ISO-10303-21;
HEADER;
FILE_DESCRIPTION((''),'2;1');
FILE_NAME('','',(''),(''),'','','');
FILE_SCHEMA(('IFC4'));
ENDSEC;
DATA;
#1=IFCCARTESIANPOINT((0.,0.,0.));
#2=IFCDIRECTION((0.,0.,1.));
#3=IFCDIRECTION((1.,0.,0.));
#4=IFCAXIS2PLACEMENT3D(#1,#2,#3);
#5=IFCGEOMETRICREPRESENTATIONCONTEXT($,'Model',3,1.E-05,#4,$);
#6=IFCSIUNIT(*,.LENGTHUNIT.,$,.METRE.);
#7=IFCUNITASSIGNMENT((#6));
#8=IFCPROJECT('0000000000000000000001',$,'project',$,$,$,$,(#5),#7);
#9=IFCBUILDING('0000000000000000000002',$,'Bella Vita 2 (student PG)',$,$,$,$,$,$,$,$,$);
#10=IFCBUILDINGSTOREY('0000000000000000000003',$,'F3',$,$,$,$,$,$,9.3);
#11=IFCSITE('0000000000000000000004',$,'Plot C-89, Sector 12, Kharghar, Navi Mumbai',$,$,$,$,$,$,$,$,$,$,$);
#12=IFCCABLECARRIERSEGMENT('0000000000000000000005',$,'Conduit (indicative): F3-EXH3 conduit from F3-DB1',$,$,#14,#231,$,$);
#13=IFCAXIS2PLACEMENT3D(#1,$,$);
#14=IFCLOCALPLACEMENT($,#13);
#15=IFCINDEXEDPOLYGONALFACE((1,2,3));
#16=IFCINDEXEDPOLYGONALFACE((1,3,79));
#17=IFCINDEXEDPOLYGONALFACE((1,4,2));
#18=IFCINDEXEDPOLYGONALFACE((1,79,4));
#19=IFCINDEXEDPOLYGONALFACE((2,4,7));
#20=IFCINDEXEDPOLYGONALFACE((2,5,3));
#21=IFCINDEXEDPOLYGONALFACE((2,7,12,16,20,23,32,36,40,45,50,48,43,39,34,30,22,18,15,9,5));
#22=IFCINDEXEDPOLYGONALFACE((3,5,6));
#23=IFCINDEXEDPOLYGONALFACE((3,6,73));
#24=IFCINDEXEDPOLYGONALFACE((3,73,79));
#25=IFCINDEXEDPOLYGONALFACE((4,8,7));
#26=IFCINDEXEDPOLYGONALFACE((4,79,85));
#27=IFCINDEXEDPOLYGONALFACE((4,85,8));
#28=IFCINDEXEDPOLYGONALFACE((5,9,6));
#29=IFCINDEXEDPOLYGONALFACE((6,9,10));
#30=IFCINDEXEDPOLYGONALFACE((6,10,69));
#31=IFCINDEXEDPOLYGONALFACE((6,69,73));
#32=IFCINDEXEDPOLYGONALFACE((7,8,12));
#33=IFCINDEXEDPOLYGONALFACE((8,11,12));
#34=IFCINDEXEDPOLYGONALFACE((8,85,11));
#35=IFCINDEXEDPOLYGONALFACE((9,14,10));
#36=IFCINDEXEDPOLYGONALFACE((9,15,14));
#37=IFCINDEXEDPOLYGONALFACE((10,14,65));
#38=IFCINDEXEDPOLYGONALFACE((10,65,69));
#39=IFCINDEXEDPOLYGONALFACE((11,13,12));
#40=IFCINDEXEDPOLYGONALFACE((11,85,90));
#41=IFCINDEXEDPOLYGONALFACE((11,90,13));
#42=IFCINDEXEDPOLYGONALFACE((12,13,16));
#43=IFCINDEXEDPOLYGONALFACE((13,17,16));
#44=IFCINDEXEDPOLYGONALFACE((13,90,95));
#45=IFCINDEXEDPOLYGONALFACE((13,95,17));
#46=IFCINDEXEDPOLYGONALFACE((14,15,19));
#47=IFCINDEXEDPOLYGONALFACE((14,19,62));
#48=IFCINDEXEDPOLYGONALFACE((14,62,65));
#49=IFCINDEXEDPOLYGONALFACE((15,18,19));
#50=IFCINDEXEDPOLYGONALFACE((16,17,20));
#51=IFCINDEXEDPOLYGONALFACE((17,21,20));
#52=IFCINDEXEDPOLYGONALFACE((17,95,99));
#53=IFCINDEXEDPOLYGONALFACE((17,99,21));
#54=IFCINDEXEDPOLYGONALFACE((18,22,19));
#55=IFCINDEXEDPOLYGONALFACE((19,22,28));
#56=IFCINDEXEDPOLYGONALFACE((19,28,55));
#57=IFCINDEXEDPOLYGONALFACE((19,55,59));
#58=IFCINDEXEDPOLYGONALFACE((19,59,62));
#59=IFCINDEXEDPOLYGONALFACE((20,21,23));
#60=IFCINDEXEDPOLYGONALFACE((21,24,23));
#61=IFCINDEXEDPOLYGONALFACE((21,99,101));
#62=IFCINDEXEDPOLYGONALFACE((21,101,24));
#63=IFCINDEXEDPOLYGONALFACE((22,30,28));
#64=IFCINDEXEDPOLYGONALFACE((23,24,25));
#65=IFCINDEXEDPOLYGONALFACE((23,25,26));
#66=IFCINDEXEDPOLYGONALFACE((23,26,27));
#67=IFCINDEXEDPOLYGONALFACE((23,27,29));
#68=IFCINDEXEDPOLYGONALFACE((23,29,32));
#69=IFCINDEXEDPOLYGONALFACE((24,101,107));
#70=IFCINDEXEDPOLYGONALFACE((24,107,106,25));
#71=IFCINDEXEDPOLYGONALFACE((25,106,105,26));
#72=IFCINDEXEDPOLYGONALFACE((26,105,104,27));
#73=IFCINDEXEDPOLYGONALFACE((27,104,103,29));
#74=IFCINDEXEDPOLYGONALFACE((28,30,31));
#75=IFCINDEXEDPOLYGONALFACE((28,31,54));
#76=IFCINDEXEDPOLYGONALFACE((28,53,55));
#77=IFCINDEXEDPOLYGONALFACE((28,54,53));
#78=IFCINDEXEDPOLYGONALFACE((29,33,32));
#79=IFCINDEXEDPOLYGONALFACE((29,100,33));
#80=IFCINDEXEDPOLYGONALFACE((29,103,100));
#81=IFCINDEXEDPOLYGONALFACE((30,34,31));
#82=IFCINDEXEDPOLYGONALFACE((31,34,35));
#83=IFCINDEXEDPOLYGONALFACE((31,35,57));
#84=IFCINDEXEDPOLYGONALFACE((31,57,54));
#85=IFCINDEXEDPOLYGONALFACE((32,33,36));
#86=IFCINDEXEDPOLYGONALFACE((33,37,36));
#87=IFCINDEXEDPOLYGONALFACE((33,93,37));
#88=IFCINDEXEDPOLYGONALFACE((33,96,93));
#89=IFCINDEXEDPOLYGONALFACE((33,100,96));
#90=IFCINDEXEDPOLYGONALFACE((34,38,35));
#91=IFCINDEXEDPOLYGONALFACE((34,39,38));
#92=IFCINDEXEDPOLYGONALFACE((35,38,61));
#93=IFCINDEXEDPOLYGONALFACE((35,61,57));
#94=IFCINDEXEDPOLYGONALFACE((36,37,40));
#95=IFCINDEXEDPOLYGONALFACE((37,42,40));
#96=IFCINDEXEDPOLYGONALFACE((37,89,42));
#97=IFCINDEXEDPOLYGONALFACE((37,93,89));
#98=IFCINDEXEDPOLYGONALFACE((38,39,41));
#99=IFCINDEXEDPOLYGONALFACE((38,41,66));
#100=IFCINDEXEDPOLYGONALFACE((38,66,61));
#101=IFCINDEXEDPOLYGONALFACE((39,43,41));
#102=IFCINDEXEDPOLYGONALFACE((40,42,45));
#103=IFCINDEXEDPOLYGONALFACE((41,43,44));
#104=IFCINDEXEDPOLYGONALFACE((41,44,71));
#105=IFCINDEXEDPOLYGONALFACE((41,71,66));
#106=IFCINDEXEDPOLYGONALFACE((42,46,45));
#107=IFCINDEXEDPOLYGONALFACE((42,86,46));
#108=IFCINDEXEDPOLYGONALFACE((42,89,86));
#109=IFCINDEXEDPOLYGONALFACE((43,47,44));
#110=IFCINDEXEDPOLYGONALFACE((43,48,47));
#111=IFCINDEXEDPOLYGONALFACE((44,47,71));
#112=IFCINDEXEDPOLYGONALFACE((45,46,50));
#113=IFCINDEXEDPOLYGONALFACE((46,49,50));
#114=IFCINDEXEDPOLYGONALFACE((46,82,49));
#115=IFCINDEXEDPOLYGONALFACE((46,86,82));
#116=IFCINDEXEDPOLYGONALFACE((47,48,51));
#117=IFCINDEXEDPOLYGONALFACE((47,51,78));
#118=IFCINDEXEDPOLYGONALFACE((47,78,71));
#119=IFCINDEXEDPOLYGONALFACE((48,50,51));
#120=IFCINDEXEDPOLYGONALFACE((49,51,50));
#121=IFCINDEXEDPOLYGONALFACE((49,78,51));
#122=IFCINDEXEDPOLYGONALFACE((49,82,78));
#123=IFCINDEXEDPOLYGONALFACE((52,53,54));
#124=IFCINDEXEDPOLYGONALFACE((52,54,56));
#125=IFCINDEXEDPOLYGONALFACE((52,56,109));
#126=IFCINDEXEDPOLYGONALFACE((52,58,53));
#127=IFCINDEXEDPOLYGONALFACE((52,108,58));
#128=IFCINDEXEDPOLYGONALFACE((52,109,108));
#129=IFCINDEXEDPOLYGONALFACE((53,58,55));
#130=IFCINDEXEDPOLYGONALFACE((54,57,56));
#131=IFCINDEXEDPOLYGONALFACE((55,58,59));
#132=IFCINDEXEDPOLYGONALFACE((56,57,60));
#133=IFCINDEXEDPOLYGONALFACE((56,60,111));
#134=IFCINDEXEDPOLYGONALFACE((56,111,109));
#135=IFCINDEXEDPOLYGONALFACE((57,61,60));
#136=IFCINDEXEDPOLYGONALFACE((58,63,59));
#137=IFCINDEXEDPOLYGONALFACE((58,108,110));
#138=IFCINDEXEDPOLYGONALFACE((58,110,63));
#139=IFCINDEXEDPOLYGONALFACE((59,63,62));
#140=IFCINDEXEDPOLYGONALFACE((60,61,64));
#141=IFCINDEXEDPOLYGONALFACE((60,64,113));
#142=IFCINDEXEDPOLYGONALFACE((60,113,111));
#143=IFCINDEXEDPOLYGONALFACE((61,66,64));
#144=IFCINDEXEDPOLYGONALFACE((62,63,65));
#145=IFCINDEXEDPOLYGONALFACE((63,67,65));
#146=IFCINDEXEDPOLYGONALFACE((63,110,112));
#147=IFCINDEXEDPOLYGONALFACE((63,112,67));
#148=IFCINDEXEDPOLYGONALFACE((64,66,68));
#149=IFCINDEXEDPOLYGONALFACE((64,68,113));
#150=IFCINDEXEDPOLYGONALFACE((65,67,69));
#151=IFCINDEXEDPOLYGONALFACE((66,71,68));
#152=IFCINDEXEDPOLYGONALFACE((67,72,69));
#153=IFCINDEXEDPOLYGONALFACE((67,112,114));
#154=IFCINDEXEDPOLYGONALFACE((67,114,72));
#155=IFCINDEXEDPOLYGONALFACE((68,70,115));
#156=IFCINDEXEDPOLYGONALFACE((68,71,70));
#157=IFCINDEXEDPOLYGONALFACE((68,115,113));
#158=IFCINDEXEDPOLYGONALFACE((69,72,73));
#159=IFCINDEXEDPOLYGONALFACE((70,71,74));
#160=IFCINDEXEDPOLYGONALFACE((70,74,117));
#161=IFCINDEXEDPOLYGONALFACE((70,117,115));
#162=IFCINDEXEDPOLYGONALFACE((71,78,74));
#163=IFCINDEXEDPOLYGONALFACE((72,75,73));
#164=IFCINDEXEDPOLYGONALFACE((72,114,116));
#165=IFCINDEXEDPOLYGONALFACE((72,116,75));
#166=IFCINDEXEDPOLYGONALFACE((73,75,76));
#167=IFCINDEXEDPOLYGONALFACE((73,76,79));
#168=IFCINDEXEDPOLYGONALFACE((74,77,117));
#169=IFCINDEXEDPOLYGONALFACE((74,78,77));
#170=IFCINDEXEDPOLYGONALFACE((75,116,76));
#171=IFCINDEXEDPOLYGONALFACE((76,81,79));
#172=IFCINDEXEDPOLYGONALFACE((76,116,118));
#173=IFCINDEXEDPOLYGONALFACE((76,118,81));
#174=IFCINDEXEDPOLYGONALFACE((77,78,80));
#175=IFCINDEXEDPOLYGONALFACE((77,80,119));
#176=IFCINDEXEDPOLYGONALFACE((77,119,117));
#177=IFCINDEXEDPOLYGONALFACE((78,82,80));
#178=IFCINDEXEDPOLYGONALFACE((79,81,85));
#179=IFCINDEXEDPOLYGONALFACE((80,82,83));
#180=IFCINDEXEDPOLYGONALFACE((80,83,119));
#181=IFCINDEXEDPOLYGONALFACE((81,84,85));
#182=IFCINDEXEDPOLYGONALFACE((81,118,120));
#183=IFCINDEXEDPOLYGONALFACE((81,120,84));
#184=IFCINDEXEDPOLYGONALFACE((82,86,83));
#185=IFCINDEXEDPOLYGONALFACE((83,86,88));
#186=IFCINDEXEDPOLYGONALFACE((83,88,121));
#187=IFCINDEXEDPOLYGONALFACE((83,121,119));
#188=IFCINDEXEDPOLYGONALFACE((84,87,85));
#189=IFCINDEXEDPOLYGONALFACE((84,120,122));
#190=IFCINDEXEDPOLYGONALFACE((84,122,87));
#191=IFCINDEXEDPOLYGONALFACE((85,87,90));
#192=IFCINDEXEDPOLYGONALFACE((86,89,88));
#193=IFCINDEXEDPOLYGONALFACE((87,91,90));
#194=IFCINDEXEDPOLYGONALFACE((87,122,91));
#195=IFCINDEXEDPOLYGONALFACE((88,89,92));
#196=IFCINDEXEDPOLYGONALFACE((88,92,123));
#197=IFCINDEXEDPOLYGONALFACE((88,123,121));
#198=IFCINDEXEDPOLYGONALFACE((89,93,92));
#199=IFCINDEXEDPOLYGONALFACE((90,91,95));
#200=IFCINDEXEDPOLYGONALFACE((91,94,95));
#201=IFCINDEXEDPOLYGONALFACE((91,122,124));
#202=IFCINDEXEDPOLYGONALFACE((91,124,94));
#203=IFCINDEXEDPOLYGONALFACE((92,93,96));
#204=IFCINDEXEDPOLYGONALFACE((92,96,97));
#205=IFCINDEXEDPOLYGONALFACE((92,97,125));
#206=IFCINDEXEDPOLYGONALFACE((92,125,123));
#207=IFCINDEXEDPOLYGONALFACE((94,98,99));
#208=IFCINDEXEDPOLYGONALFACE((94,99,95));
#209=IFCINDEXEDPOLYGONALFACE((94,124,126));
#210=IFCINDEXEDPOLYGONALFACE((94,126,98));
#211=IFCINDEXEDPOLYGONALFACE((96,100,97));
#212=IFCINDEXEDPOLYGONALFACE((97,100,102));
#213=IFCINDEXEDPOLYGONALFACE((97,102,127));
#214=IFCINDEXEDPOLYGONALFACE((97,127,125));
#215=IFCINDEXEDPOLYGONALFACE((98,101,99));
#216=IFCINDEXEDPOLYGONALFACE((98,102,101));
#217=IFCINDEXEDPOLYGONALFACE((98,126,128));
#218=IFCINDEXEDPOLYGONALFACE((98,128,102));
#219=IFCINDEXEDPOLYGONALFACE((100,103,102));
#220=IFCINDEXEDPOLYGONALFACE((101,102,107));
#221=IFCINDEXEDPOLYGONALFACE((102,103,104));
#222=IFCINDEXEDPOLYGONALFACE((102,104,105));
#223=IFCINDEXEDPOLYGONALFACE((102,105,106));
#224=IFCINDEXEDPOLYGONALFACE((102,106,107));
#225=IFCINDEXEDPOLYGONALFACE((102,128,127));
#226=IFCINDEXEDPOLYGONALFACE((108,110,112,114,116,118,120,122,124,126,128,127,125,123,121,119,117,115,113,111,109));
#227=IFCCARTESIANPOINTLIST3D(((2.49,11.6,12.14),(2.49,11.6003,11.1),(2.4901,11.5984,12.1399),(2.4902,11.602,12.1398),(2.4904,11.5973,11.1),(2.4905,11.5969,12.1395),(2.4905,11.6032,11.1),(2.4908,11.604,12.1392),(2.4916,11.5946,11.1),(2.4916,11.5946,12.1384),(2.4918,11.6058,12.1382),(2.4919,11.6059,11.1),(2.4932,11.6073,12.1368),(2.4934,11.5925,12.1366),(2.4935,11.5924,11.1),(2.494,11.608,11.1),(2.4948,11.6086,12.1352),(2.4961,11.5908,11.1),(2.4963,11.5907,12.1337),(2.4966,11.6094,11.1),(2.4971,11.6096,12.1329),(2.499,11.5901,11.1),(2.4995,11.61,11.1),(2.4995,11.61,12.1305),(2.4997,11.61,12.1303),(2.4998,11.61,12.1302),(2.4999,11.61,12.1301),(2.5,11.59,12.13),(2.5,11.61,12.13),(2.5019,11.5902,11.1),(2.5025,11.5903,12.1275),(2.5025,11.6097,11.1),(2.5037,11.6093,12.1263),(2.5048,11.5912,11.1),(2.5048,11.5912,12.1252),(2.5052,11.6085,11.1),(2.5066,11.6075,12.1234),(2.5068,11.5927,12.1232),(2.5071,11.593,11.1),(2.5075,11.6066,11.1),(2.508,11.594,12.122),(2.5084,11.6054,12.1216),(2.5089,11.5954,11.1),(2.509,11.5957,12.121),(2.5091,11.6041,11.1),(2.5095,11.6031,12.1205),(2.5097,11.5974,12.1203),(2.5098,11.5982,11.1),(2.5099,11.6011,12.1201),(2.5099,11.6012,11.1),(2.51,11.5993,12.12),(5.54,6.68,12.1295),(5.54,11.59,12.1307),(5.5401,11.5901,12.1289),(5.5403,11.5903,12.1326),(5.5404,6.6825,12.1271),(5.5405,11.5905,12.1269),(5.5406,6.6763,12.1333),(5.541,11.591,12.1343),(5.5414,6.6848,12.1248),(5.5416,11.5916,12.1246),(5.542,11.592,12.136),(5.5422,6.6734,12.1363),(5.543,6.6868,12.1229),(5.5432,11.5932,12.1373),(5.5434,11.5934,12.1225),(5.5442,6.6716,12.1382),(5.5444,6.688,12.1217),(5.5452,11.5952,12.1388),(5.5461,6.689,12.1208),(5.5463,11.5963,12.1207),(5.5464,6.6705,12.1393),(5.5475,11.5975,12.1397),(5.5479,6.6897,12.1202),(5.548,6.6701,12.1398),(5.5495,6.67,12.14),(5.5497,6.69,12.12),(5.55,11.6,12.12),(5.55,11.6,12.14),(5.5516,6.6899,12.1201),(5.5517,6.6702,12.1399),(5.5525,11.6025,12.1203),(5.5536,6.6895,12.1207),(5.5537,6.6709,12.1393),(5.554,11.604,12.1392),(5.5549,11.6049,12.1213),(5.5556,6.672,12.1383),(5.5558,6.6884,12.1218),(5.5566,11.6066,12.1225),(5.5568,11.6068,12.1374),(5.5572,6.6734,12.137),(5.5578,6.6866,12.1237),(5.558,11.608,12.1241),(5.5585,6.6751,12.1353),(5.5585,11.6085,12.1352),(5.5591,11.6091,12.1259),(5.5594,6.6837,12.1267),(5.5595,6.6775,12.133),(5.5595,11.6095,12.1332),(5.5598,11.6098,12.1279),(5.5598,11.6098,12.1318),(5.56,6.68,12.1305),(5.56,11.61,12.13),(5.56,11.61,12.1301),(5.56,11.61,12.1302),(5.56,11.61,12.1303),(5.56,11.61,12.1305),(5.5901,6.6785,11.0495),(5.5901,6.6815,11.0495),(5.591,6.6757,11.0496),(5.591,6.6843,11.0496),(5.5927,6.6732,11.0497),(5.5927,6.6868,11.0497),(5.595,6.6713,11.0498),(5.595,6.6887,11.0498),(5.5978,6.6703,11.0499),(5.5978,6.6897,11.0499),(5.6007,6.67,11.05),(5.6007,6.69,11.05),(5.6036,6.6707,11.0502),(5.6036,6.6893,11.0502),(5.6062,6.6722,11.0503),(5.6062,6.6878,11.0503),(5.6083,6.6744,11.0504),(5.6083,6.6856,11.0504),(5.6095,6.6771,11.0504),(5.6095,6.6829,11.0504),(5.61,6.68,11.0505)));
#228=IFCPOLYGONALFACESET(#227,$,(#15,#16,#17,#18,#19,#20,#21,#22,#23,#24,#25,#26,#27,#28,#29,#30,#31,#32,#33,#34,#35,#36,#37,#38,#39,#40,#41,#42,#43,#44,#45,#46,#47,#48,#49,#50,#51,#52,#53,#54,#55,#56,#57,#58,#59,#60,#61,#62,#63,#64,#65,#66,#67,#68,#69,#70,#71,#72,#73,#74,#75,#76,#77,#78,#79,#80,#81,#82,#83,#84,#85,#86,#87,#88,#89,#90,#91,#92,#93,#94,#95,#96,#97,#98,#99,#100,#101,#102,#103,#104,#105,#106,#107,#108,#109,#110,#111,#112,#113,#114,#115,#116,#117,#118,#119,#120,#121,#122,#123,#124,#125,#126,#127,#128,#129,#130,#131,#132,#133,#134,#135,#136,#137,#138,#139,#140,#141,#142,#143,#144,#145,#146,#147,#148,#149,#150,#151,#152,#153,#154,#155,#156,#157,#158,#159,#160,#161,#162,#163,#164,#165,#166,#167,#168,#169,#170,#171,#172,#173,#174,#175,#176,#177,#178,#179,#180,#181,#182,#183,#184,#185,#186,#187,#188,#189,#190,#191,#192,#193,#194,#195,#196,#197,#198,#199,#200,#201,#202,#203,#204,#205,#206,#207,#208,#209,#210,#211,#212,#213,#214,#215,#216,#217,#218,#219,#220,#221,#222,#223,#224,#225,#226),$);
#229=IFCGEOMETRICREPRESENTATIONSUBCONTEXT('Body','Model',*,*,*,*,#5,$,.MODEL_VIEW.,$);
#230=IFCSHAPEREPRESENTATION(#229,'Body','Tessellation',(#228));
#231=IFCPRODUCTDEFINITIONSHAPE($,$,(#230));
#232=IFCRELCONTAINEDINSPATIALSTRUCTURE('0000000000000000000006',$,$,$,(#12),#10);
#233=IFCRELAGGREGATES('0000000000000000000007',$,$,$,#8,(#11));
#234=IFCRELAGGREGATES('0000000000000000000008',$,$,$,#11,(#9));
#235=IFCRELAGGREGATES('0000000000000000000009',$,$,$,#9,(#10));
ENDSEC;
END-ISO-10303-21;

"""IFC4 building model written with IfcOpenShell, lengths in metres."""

from ifc_helpers import new_model, entity, si_unit, origin, origin_with_axes, place, context, subcontext, project, spatial, element, save


model = new_model("IFC4")

# Units and contexts
model_context = context("Model", 3, precision=1e-05, world=origin_with_axes())
body_context = subcontext(model_context, "Body", "Model", "MODEL_VIEW")
ifc_project = project(units=[si_unit("LENGTHUNIT", "METRE")], contexts=[model_context])

# Site, building, storey
site = spatial("IfcSite", under=ifc_project, Name="Plot C-89, Sector 12, Kharghar, Navi Mumbai")
building = spatial("IfcBuilding", under=site, Name="Bella Vita 2 (student PG)")
storey = spatial("IfcBuildingStorey", under=building, Name="F3", Elevation=9.3)

# Cable carrier segment
cable_carrier_segment_1_placement = place(None, origin())
element("IfcCableCarrierSegment", 1, at=cable_carrier_segment_1_placement, inside=storey, Name="Conduit (indicative): F3-EXH3 conduit from F3-DB1", context=body_context, shape_type="AdvancedSweptSolid", body=[
    entity("IfcSweptDiskSolid", entity("IfcPolyline", [entity("IfcCartesianPoint", [5.6, 6.68, 11.05]), entity("IfcCartesianPoint", [5.55, 6.68, 12.13]), entity("IfcCartesianPoint", [5.55, 11.6, 12.13]), entity("IfcCartesianPoint", [2.5, 11.6, 12.13]), entity("IfcCartesianPoint", [2.5, 11.6, 11.1])]), 0.01),
])

save(model, "model.ifc")
